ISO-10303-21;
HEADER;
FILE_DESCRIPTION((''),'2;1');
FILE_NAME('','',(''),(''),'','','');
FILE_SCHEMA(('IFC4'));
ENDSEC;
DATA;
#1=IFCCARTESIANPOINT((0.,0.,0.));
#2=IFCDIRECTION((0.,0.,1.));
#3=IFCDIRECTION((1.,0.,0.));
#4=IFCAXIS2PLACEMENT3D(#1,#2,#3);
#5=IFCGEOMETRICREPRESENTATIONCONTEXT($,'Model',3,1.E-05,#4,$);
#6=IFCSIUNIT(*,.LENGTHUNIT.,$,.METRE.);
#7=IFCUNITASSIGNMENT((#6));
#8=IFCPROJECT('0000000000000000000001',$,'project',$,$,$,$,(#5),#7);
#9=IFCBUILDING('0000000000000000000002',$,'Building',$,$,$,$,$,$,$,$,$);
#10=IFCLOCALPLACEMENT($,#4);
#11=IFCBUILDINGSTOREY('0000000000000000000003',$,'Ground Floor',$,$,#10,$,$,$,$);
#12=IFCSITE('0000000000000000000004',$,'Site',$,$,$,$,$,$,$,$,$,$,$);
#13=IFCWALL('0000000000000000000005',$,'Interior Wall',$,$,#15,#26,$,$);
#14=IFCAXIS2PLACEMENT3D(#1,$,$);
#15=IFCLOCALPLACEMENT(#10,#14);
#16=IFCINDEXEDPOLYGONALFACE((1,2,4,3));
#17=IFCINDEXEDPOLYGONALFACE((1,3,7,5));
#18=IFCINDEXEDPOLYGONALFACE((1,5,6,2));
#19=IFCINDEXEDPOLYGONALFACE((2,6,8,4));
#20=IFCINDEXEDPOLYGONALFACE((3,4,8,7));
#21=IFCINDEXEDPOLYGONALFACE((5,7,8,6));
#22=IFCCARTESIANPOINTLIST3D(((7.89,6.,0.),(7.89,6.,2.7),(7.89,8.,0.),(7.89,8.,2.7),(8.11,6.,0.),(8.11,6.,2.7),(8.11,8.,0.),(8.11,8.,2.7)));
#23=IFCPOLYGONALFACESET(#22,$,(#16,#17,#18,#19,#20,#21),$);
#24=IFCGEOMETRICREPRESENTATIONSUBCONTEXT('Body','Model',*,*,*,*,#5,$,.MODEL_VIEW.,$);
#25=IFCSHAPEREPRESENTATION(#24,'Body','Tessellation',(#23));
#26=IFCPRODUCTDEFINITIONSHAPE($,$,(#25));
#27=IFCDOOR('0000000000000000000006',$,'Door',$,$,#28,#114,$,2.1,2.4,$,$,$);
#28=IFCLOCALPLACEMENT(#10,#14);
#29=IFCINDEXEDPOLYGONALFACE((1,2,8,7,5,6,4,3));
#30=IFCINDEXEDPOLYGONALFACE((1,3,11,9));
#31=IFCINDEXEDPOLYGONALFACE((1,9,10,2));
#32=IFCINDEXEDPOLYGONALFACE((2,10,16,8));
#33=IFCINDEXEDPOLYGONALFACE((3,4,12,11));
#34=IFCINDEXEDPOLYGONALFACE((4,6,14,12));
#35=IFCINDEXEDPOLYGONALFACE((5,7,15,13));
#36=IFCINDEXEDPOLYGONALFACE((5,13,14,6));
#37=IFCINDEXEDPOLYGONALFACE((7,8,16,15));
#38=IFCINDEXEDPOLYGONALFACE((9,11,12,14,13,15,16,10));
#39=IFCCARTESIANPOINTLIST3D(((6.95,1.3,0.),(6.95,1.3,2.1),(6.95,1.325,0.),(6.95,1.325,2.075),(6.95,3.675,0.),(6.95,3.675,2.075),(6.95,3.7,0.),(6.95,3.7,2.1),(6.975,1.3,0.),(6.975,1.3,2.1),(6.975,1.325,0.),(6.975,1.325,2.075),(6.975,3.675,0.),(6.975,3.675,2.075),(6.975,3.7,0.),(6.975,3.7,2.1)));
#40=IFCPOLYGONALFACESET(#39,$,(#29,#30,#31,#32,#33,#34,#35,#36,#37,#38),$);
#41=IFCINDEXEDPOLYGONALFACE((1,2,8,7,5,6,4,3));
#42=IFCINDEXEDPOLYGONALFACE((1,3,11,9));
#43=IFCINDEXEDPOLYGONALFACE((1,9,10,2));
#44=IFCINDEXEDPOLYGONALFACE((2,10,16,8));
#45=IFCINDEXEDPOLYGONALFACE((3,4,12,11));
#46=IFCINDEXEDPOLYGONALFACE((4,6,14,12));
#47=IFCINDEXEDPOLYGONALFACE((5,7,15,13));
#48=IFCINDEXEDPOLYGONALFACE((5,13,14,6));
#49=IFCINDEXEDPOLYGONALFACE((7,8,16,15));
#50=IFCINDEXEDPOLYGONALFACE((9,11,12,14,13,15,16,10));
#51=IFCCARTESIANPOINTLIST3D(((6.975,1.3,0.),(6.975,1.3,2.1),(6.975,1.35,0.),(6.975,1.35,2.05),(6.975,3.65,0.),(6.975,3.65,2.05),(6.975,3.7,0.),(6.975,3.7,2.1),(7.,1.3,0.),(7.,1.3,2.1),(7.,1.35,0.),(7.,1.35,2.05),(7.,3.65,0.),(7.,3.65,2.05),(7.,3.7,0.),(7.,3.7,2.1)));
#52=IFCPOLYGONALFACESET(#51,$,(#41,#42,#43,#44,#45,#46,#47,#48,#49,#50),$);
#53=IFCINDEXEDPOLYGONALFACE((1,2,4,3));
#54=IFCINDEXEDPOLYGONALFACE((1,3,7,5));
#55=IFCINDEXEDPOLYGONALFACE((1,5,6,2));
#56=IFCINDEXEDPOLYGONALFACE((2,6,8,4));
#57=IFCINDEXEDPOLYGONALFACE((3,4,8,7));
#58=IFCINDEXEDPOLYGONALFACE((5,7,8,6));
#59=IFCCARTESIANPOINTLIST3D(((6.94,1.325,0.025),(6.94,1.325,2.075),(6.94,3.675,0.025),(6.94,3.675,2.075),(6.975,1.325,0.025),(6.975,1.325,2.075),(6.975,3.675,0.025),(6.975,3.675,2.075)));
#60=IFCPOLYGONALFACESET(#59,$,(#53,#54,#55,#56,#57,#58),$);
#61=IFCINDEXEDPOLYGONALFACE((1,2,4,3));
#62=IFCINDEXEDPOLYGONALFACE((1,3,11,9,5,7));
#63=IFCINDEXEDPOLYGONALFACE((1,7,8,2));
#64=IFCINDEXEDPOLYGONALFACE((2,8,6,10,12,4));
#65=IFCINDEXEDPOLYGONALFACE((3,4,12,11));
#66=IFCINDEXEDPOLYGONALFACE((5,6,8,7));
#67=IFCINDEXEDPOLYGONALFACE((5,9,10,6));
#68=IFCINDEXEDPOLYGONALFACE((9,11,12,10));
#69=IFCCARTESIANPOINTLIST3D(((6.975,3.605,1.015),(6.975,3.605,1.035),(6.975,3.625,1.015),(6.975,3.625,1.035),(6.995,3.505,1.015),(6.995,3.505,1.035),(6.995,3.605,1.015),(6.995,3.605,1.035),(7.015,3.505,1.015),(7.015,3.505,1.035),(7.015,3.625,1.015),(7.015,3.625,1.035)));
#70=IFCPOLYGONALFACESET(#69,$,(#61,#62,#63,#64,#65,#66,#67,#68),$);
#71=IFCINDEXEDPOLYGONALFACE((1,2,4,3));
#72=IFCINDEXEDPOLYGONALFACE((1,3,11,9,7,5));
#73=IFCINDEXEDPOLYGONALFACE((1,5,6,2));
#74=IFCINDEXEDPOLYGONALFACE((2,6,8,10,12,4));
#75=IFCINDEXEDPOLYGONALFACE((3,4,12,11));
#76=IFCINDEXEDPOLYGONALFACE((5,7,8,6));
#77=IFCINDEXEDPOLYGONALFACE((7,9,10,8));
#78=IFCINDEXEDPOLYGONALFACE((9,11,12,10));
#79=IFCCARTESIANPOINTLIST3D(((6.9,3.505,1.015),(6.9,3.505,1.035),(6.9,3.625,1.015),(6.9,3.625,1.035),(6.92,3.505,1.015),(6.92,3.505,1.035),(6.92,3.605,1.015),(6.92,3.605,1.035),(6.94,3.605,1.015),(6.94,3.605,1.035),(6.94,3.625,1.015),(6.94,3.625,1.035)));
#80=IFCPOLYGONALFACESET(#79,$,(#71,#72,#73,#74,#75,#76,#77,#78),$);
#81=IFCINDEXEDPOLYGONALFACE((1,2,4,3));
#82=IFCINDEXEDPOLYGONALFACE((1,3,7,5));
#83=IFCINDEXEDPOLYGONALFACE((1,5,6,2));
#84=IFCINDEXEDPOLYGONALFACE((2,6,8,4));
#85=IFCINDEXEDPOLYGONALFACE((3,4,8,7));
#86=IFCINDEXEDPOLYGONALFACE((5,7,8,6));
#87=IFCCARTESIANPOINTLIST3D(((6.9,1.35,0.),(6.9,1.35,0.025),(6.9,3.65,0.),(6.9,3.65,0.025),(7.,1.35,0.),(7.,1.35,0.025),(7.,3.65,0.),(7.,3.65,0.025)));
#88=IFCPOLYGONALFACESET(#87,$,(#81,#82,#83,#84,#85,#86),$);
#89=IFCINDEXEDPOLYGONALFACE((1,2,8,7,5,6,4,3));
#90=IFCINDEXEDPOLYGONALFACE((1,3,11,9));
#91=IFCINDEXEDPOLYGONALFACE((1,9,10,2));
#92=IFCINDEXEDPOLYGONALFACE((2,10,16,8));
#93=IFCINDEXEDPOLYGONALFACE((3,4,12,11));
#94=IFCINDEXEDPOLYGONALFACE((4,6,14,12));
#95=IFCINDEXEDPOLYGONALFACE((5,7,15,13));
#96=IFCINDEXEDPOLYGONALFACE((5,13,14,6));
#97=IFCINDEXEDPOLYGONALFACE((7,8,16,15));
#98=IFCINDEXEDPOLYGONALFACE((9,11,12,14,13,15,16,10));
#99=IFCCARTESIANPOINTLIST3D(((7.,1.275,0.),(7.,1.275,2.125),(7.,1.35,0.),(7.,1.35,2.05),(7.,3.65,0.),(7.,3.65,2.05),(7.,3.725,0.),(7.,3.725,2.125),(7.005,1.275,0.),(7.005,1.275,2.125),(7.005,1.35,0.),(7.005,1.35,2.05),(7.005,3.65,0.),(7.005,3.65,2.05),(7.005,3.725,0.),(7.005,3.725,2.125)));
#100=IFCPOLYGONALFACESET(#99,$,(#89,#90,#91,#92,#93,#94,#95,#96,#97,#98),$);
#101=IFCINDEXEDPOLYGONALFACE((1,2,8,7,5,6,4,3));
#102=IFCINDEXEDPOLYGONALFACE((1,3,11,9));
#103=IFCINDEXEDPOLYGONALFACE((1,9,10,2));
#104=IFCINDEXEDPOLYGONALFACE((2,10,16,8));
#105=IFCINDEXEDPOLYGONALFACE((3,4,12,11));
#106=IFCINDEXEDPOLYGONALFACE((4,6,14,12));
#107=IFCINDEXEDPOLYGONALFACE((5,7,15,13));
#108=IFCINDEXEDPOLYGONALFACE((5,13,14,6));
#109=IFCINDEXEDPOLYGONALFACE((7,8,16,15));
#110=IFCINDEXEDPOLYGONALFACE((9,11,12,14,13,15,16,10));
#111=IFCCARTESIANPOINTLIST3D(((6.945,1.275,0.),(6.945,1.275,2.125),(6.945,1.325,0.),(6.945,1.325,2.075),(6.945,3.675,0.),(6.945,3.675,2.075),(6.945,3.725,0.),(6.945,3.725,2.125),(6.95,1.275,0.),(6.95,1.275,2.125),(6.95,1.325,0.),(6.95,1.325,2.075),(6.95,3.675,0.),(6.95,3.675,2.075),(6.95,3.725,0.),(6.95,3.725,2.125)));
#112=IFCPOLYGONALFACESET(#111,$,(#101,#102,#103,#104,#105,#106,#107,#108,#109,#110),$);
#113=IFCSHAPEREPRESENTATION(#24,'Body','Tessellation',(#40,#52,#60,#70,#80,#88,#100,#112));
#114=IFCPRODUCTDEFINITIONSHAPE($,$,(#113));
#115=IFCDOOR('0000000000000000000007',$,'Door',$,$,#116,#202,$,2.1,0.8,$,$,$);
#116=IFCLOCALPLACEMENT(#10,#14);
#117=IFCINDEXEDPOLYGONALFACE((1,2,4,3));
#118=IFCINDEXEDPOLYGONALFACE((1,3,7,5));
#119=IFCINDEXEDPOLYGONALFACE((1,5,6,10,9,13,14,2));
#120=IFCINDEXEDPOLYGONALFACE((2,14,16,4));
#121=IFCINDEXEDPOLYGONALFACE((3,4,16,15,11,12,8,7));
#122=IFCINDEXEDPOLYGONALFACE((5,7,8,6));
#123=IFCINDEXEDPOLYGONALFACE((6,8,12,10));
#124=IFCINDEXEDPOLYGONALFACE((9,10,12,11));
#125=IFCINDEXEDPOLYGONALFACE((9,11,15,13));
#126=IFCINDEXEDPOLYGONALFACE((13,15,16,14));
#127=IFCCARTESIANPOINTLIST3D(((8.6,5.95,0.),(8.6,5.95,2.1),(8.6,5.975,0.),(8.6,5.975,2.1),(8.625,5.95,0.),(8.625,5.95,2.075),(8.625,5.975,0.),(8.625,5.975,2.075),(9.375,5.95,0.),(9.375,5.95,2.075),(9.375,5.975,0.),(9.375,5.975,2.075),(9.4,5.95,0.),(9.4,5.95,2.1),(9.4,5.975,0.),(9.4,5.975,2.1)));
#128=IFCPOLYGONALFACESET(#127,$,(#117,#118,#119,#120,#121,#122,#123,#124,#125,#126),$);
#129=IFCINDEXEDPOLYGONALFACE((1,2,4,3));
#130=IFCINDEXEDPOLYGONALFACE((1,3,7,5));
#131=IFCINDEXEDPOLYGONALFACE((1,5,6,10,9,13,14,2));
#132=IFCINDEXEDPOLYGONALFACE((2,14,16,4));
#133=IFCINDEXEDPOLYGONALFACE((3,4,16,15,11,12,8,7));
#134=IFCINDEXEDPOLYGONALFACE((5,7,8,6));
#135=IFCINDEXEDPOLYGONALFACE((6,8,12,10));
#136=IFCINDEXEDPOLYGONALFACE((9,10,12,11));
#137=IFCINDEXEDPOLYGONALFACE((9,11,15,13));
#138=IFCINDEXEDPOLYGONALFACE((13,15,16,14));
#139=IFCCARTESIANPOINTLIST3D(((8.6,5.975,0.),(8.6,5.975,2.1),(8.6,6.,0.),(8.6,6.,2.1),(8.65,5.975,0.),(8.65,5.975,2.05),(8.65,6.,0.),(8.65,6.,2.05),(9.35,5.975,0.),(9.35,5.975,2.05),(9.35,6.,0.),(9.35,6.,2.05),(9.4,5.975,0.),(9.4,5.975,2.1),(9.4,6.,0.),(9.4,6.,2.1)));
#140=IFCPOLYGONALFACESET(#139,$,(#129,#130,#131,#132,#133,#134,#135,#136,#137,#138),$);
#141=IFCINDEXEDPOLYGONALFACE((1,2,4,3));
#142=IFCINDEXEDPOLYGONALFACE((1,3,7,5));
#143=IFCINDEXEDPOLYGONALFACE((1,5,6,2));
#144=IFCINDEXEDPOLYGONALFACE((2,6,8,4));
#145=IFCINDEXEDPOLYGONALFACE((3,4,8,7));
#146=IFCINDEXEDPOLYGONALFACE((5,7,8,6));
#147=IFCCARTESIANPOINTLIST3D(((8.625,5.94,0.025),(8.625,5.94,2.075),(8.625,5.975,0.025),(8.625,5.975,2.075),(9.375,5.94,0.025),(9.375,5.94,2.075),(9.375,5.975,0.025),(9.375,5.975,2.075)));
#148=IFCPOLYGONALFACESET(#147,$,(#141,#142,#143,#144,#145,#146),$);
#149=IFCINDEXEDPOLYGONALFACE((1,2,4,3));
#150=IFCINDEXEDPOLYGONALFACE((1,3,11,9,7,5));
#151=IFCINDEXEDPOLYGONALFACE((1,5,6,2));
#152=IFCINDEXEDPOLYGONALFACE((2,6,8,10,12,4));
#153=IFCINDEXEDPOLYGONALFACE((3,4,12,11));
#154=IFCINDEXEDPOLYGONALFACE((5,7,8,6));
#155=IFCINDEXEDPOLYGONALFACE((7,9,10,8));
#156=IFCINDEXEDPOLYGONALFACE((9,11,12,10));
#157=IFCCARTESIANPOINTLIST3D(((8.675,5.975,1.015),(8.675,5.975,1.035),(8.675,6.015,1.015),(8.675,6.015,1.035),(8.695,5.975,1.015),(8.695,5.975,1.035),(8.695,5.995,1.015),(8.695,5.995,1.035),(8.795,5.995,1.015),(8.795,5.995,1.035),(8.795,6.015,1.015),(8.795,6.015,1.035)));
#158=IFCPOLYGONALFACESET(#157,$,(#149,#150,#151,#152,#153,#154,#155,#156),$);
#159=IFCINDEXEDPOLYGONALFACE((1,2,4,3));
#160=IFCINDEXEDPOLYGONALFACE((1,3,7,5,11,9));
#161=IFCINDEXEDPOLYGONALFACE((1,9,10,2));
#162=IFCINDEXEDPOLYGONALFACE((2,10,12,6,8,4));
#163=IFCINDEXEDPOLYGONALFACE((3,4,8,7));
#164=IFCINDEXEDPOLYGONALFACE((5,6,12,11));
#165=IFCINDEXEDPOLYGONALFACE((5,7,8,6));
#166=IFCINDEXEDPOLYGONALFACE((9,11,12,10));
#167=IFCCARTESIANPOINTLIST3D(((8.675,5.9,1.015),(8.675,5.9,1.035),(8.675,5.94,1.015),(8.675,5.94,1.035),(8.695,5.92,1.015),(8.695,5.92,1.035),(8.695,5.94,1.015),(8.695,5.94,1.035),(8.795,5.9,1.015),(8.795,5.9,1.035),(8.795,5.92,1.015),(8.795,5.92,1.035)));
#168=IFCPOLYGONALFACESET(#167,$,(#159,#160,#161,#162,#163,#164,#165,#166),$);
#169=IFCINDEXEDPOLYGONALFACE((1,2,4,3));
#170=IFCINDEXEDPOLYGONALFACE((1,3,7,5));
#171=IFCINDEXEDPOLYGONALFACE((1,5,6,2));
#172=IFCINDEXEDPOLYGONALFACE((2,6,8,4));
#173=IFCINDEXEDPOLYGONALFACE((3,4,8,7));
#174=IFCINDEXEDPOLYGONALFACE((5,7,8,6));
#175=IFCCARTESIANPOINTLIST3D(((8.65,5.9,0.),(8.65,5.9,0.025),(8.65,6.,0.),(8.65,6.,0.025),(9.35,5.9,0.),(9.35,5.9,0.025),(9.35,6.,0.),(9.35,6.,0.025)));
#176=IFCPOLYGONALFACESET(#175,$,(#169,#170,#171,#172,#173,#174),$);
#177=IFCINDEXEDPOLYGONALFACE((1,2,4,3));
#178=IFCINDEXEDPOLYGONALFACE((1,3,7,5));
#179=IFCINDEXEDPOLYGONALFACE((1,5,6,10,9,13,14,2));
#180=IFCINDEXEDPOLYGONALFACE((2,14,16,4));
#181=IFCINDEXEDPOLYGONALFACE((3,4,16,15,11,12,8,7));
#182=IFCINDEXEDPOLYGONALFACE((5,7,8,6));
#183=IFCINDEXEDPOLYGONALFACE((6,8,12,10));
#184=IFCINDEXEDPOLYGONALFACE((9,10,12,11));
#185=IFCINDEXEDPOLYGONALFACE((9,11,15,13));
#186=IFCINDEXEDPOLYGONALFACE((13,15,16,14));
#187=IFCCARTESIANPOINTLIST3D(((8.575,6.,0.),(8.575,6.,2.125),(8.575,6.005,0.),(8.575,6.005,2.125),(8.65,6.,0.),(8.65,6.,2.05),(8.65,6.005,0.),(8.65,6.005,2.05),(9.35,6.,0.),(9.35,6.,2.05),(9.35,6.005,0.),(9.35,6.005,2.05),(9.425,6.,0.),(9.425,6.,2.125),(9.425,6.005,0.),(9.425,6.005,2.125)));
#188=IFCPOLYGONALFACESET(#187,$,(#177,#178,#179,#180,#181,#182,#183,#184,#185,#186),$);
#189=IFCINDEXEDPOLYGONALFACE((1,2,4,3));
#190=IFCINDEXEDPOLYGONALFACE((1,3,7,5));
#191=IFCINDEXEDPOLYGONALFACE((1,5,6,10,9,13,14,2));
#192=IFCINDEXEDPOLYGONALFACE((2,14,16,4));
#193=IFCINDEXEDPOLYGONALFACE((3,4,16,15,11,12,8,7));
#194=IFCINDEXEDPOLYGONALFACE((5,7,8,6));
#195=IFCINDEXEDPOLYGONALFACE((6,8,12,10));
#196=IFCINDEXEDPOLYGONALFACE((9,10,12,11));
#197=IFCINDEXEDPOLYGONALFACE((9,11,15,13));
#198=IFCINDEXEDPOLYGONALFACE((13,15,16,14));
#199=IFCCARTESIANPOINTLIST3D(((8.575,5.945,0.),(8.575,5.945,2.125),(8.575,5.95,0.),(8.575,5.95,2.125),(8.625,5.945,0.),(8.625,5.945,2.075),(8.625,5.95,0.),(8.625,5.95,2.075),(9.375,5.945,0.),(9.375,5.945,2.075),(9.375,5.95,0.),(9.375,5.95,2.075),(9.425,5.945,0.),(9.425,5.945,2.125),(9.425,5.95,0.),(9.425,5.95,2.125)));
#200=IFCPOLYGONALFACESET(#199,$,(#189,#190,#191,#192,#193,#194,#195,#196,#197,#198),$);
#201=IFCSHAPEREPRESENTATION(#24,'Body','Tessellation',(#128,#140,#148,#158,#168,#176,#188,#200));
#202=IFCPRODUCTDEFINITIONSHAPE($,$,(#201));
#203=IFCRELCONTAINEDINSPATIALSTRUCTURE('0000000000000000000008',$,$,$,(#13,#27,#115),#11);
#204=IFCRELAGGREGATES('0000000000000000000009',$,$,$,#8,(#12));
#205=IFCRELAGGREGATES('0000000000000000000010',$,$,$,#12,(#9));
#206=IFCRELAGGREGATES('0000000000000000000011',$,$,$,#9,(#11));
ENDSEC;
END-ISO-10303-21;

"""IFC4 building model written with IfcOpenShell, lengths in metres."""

from ifc_helpers import new_model, si_unit, frame, origin_with_axes, place, context, subcontext, project, spatial, line, indexed_curve, outline, extrude, element, save


model = new_model("IFC4")

# Units and contexts
model_context = context("Model", 3, precision=1e-05, world=origin_with_axes())
body_context = subcontext(model_context, "Body", "Model", "MODEL_VIEW")
ifc_project = project(units=[si_unit("LENGTHUNIT", "METRE")], contexts=[model_context])

# Site, building, storey
site = spatial("IfcSite", under=ifc_project, Name="Site")
building = spatial("IfcBuilding", under=site, Name="Building")
storey_placement = place(None, origin_with_axes())
storey = spatial("IfcBuildingStorey", under=building, at=storey_placement, Name="Ground Floor")

# Wall
wall_1_placement = place(storey_placement, frame((8.0, 6.0, 0.0), z_axis=(0.0, 0.0, 1.0), x_axis=(0.0, 1.0, 0.0)))
element("IfcWall", 1, at=wall_1_placement, inside=storey, Name="Interior Wall", context=body_context, shape_type="SweptSolid", body=[
    extrude(outline(indexed_curve([(0.0, 0.0), (0.0, 0.22), (2.0, 0.22), (2.0, 0.0), (0.0, 0.0)], self_intersect=False)), frame((0.0, -0.11, 0.0), z_axis=(0.0, 0.0, 1.0), x_axis=(1.0, 0.0, 0.0)), (0.0, 0.0, 1.0), 2.7),
])

# Doors
door_1_placement = place(storey_placement, frame((7.0, 1.3, 0.0), z_axis=(0.0, 0.0, 1.0), x_axis=(0.0, 1.0, 0.0)))
element("IfcDoor", 2, at=door_1_placement, inside=storey, Name="Door", OverallHeight=2.1, OverallWidth=2.4, context=body_context, shape_type="SweptSolid", body=[
    extrude(outline(indexed_curve([(0.0, 0.0), (0.0, 2.1), (2.4, 2.1), (2.4, 0.0), (2.375, 0.0), (2.375, 2.075), (0.025, 2.075), (0.025, 0.0)], segments=[line(1, 2, 3, 4, 5, 6, 7, 8, 1)])), frame((0.0, 0.025, 0.0), z_axis=(0.0, -1.0, 0.0), x_axis=(1.0, 0.0, 0.0)), (0.0, 0.0, -1.0), 0.025),
    extrude(outline(indexed_curve([(0.0, 0.0), (0.0, 2.1), (2.4, 2.1), (2.4, 0.0), (2.35, 0.0), (2.35, 2.05), (0.05, 2.05), (0.05, 0.0)], segments=[line(1, 2, 3, 4, 5, 6, 7, 8, 1)])), frame((0.0, 0.0, 0.0), z_axis=(0.0, -1.0, 0.0), x_axis=(1.0, 0.0, 0.0)), (0.0, 0.0, -1.0), 0.025),
    extrude(outline(indexed_curve([(0.0, 0.0), (2.35, 0.0), (2.35, 0.035), (0.0, 0.035)], segments=[line(1, 2, 3, 4, 1)])), frame((0.025, 0.025, 0.025), z_axis=(0.0, 0.0, 1.0), x_axis=(1.0, 0.0, 0.0)), (0.0, 0.0, 1.0), 2.05),
    extrude(outline(indexed_curve([(0.0, 0.0), (0.0, -0.04), (-0.12, -0.04), (-0.12, -0.02), (-0.02, -0.02), (-0.02, 0.0)], segments=[line(1, 2, 3, 4, 5, 6, 1)])), frame((2.325, 0.025, 1.015), z_axis=(0.0, 0.0, 1.0), x_axis=(1.0, 0.0, 0.0)), (0.0, 0.0, 1.0), 0.02),
    extrude(outline(indexed_curve([(0.0, 0.0), (0.0, 0.04), (-0.12, 0.04), (-0.12, 0.02), (-0.02, 0.02), (-0.02, 0.0)], segments=[line(1, 2, 3, 4, 5, 6, 1)])), frame((2.325, 0.06, 1.015), z_axis=(0.0, 0.0, 1.0), x_axis=(1.0, 0.0, 0.0)), (0.0, 0.0, 1.0), 0.02),
    extrude(outline(indexed_curve([(0.0, 0.0), (2.3, 0.0), (2.3, 0.1), (0.0, 0.1)], segments=[line(1, 2, 3, 4, 1)])), frame((0.05, 0.0, 0.0), z_axis=(0.0, 0.0, 1.0), x_axis=(1.0, 0.0, 0.0)), (0.0, 0.0, 1.0), 0.025),
    extrude(outline(indexed_curve([(0.0, 0.0), (0.0, 2.125), (2.45, 2.125), (2.45, 0.0), (2.375, 0.0), (2.375, 2.05), (0.075, 2.05), (0.075, 0.0)], segments=[line(1, 2, 3, 4, 5, 6, 7, 8, 1)])), frame((-0.025, -0.005, 0.0), z_axis=(0.0, -1.0, 0.0), x_axis=(1.0, 0.0, 0.0)), (0.0, 0.0, -1.0), 0.005),
    extrude(outline(indexed_curve([(0.0, 0.0), (0.0, 2.125), (2.45, 2.125), (2.45, 0.0), (2.4, 0.0), (2.4, 2.075), (0.05, 2.075), (0.05, 0.0)], segments=[line(1, 2, 3, 4, 5, 6, 7, 8, 1)])), frame((-0.025, 0.05, 0.0), z_axis=(0.0, -1.0, 0.0), x_axis=(1.0, 0.0, 0.0)), (0.0, 0.0, -1.0), 0.005),
])
door_2_placement = place(storey_placement, frame((9.4, 6.0, 0.0), z_axis=(0.0, 0.0, 1.0), x_axis=(-1.0, 0.0, 0.0)))
element("IfcDoor", 3, at=door_2_placement, inside=storey, Name="Door", OverallHeight=2.1, OverallWidth=0.8, context=body_context, shape_type="SweptSolid", body=[
    extrude(outline(indexed_curve([(0.0, 0.0), (0.0, 2.1), (0.8, 2.1), (0.8, 0.0), (0.775, 0.0), (0.775, 2.075), (0.025, 2.075), (0.025, 0.0)], segments=[line(1, 2, 3, 4, 5, 6, 7, 8, 1)])), frame((0.0, 0.025, 0.0), z_axis=(0.0, -1.0, 0.0), x_axis=(1.0, 0.0, 0.0)), (0.0, 0.0, -1.0), 0.025),
    extrude(outline(indexed_curve([(0.0, 0.0), (0.0, 2.1), (0.8, 2.1), (0.8, 0.0), (0.75, 0.0), (0.75, 2.05), (0.05, 2.05), (0.05, 0.0)], segments=[line(1, 2, 3, 4, 5, 6, 7, 8, 1)])), frame((0.0, 0.0, 0.0), z_axis=(0.0, -1.0, 0.0), x_axis=(1.0, 0.0, 0.0)), (0.0, 0.0, -1.0), 0.025),
    extrude(outline(indexed_curve([(0.0, 0.0), (0.75, 0.0), (0.75, 0.035), (0.0, 0.035)], segments=[line(1, 2, 3, 4, 1)])), frame((0.025, 0.025, 0.025), z_axis=(0.0, 0.0, 1.0), x_axis=(1.0, 0.0, 0.0)), (0.0, 0.0, 1.0), 2.05),
    extrude(outline(indexed_curve([(0.0, 0.0), (0.0, -0.04), (-0.12, -0.04), (-0.12, -0.02), (-0.02, -0.02), (-0.02, 0.0)], segments=[line(1, 2, 3, 4, 5, 6, 1)])), frame((0.725, 0.025, 1.015), z_axis=(0.0, 0.0, 1.0), x_axis=(1.0, 0.0, 0.0)), (0.0, 0.0, 1.0), 0.02),
    extrude(outline(indexed_curve([(0.0, 0.0), (0.0, 0.04), (-0.12, 0.04), (-0.12, 0.02), (-0.02, 0.02), (-0.02, 0.0)], segments=[line(1, 2, 3, 4, 5, 6, 1)])), frame((0.725, 0.06, 1.015), z_axis=(0.0, 0.0, 1.0), x_axis=(1.0, 0.0, 0.0)), (0.0, 0.0, 1.0), 0.02),
    extrude(outline(indexed_curve([(0.0, 0.0), (0.7, 0.0), (0.7, 0.1), (0.0, 0.1)], segments=[line(1, 2, 3, 4, 1)])), frame((0.05, 0.0, 0.0), z_axis=(0.0, 0.0, 1.0), x_axis=(1.0, 0.0, 0.0)), (0.0, 0.0, 1.0), 0.025),
    extrude(outline(indexed_curve([(0.0, 0.0), (0.0, 2.125), (0.85, 2.125), (0.85, 0.0), (0.775, 0.0), (0.775, 2.05), (0.075, 2.05), (0.075, 0.0)], segments=[line(1, 2, 3, 4, 5, 6, 7, 8, 1)])), frame((-0.025, -0.005, 0.0), z_axis=(0.0, -1.0, 0.0), x_axis=(1.0, 0.0, 0.0)), (0.0, 0.0, -1.0), 0.005),
    extrude(outline(indexed_curve([(0.0, 0.0), (0.0, 2.125), (0.85, 2.125), (0.85, 0.0), (0.8, 0.0), (0.8, 2.075), (0.05, 2.075), (0.05, 0.0)], segments=[line(1, 2, 3, 4, 5, 6, 7, 8, 1)])), frame((-0.025, 0.05, 0.0), z_axis=(0.0, -1.0, 0.0), x_axis=(1.0, 0.0, 0.0)), (0.0, 0.0, -1.0), 0.005),
])

save(model, "model.ifc")
